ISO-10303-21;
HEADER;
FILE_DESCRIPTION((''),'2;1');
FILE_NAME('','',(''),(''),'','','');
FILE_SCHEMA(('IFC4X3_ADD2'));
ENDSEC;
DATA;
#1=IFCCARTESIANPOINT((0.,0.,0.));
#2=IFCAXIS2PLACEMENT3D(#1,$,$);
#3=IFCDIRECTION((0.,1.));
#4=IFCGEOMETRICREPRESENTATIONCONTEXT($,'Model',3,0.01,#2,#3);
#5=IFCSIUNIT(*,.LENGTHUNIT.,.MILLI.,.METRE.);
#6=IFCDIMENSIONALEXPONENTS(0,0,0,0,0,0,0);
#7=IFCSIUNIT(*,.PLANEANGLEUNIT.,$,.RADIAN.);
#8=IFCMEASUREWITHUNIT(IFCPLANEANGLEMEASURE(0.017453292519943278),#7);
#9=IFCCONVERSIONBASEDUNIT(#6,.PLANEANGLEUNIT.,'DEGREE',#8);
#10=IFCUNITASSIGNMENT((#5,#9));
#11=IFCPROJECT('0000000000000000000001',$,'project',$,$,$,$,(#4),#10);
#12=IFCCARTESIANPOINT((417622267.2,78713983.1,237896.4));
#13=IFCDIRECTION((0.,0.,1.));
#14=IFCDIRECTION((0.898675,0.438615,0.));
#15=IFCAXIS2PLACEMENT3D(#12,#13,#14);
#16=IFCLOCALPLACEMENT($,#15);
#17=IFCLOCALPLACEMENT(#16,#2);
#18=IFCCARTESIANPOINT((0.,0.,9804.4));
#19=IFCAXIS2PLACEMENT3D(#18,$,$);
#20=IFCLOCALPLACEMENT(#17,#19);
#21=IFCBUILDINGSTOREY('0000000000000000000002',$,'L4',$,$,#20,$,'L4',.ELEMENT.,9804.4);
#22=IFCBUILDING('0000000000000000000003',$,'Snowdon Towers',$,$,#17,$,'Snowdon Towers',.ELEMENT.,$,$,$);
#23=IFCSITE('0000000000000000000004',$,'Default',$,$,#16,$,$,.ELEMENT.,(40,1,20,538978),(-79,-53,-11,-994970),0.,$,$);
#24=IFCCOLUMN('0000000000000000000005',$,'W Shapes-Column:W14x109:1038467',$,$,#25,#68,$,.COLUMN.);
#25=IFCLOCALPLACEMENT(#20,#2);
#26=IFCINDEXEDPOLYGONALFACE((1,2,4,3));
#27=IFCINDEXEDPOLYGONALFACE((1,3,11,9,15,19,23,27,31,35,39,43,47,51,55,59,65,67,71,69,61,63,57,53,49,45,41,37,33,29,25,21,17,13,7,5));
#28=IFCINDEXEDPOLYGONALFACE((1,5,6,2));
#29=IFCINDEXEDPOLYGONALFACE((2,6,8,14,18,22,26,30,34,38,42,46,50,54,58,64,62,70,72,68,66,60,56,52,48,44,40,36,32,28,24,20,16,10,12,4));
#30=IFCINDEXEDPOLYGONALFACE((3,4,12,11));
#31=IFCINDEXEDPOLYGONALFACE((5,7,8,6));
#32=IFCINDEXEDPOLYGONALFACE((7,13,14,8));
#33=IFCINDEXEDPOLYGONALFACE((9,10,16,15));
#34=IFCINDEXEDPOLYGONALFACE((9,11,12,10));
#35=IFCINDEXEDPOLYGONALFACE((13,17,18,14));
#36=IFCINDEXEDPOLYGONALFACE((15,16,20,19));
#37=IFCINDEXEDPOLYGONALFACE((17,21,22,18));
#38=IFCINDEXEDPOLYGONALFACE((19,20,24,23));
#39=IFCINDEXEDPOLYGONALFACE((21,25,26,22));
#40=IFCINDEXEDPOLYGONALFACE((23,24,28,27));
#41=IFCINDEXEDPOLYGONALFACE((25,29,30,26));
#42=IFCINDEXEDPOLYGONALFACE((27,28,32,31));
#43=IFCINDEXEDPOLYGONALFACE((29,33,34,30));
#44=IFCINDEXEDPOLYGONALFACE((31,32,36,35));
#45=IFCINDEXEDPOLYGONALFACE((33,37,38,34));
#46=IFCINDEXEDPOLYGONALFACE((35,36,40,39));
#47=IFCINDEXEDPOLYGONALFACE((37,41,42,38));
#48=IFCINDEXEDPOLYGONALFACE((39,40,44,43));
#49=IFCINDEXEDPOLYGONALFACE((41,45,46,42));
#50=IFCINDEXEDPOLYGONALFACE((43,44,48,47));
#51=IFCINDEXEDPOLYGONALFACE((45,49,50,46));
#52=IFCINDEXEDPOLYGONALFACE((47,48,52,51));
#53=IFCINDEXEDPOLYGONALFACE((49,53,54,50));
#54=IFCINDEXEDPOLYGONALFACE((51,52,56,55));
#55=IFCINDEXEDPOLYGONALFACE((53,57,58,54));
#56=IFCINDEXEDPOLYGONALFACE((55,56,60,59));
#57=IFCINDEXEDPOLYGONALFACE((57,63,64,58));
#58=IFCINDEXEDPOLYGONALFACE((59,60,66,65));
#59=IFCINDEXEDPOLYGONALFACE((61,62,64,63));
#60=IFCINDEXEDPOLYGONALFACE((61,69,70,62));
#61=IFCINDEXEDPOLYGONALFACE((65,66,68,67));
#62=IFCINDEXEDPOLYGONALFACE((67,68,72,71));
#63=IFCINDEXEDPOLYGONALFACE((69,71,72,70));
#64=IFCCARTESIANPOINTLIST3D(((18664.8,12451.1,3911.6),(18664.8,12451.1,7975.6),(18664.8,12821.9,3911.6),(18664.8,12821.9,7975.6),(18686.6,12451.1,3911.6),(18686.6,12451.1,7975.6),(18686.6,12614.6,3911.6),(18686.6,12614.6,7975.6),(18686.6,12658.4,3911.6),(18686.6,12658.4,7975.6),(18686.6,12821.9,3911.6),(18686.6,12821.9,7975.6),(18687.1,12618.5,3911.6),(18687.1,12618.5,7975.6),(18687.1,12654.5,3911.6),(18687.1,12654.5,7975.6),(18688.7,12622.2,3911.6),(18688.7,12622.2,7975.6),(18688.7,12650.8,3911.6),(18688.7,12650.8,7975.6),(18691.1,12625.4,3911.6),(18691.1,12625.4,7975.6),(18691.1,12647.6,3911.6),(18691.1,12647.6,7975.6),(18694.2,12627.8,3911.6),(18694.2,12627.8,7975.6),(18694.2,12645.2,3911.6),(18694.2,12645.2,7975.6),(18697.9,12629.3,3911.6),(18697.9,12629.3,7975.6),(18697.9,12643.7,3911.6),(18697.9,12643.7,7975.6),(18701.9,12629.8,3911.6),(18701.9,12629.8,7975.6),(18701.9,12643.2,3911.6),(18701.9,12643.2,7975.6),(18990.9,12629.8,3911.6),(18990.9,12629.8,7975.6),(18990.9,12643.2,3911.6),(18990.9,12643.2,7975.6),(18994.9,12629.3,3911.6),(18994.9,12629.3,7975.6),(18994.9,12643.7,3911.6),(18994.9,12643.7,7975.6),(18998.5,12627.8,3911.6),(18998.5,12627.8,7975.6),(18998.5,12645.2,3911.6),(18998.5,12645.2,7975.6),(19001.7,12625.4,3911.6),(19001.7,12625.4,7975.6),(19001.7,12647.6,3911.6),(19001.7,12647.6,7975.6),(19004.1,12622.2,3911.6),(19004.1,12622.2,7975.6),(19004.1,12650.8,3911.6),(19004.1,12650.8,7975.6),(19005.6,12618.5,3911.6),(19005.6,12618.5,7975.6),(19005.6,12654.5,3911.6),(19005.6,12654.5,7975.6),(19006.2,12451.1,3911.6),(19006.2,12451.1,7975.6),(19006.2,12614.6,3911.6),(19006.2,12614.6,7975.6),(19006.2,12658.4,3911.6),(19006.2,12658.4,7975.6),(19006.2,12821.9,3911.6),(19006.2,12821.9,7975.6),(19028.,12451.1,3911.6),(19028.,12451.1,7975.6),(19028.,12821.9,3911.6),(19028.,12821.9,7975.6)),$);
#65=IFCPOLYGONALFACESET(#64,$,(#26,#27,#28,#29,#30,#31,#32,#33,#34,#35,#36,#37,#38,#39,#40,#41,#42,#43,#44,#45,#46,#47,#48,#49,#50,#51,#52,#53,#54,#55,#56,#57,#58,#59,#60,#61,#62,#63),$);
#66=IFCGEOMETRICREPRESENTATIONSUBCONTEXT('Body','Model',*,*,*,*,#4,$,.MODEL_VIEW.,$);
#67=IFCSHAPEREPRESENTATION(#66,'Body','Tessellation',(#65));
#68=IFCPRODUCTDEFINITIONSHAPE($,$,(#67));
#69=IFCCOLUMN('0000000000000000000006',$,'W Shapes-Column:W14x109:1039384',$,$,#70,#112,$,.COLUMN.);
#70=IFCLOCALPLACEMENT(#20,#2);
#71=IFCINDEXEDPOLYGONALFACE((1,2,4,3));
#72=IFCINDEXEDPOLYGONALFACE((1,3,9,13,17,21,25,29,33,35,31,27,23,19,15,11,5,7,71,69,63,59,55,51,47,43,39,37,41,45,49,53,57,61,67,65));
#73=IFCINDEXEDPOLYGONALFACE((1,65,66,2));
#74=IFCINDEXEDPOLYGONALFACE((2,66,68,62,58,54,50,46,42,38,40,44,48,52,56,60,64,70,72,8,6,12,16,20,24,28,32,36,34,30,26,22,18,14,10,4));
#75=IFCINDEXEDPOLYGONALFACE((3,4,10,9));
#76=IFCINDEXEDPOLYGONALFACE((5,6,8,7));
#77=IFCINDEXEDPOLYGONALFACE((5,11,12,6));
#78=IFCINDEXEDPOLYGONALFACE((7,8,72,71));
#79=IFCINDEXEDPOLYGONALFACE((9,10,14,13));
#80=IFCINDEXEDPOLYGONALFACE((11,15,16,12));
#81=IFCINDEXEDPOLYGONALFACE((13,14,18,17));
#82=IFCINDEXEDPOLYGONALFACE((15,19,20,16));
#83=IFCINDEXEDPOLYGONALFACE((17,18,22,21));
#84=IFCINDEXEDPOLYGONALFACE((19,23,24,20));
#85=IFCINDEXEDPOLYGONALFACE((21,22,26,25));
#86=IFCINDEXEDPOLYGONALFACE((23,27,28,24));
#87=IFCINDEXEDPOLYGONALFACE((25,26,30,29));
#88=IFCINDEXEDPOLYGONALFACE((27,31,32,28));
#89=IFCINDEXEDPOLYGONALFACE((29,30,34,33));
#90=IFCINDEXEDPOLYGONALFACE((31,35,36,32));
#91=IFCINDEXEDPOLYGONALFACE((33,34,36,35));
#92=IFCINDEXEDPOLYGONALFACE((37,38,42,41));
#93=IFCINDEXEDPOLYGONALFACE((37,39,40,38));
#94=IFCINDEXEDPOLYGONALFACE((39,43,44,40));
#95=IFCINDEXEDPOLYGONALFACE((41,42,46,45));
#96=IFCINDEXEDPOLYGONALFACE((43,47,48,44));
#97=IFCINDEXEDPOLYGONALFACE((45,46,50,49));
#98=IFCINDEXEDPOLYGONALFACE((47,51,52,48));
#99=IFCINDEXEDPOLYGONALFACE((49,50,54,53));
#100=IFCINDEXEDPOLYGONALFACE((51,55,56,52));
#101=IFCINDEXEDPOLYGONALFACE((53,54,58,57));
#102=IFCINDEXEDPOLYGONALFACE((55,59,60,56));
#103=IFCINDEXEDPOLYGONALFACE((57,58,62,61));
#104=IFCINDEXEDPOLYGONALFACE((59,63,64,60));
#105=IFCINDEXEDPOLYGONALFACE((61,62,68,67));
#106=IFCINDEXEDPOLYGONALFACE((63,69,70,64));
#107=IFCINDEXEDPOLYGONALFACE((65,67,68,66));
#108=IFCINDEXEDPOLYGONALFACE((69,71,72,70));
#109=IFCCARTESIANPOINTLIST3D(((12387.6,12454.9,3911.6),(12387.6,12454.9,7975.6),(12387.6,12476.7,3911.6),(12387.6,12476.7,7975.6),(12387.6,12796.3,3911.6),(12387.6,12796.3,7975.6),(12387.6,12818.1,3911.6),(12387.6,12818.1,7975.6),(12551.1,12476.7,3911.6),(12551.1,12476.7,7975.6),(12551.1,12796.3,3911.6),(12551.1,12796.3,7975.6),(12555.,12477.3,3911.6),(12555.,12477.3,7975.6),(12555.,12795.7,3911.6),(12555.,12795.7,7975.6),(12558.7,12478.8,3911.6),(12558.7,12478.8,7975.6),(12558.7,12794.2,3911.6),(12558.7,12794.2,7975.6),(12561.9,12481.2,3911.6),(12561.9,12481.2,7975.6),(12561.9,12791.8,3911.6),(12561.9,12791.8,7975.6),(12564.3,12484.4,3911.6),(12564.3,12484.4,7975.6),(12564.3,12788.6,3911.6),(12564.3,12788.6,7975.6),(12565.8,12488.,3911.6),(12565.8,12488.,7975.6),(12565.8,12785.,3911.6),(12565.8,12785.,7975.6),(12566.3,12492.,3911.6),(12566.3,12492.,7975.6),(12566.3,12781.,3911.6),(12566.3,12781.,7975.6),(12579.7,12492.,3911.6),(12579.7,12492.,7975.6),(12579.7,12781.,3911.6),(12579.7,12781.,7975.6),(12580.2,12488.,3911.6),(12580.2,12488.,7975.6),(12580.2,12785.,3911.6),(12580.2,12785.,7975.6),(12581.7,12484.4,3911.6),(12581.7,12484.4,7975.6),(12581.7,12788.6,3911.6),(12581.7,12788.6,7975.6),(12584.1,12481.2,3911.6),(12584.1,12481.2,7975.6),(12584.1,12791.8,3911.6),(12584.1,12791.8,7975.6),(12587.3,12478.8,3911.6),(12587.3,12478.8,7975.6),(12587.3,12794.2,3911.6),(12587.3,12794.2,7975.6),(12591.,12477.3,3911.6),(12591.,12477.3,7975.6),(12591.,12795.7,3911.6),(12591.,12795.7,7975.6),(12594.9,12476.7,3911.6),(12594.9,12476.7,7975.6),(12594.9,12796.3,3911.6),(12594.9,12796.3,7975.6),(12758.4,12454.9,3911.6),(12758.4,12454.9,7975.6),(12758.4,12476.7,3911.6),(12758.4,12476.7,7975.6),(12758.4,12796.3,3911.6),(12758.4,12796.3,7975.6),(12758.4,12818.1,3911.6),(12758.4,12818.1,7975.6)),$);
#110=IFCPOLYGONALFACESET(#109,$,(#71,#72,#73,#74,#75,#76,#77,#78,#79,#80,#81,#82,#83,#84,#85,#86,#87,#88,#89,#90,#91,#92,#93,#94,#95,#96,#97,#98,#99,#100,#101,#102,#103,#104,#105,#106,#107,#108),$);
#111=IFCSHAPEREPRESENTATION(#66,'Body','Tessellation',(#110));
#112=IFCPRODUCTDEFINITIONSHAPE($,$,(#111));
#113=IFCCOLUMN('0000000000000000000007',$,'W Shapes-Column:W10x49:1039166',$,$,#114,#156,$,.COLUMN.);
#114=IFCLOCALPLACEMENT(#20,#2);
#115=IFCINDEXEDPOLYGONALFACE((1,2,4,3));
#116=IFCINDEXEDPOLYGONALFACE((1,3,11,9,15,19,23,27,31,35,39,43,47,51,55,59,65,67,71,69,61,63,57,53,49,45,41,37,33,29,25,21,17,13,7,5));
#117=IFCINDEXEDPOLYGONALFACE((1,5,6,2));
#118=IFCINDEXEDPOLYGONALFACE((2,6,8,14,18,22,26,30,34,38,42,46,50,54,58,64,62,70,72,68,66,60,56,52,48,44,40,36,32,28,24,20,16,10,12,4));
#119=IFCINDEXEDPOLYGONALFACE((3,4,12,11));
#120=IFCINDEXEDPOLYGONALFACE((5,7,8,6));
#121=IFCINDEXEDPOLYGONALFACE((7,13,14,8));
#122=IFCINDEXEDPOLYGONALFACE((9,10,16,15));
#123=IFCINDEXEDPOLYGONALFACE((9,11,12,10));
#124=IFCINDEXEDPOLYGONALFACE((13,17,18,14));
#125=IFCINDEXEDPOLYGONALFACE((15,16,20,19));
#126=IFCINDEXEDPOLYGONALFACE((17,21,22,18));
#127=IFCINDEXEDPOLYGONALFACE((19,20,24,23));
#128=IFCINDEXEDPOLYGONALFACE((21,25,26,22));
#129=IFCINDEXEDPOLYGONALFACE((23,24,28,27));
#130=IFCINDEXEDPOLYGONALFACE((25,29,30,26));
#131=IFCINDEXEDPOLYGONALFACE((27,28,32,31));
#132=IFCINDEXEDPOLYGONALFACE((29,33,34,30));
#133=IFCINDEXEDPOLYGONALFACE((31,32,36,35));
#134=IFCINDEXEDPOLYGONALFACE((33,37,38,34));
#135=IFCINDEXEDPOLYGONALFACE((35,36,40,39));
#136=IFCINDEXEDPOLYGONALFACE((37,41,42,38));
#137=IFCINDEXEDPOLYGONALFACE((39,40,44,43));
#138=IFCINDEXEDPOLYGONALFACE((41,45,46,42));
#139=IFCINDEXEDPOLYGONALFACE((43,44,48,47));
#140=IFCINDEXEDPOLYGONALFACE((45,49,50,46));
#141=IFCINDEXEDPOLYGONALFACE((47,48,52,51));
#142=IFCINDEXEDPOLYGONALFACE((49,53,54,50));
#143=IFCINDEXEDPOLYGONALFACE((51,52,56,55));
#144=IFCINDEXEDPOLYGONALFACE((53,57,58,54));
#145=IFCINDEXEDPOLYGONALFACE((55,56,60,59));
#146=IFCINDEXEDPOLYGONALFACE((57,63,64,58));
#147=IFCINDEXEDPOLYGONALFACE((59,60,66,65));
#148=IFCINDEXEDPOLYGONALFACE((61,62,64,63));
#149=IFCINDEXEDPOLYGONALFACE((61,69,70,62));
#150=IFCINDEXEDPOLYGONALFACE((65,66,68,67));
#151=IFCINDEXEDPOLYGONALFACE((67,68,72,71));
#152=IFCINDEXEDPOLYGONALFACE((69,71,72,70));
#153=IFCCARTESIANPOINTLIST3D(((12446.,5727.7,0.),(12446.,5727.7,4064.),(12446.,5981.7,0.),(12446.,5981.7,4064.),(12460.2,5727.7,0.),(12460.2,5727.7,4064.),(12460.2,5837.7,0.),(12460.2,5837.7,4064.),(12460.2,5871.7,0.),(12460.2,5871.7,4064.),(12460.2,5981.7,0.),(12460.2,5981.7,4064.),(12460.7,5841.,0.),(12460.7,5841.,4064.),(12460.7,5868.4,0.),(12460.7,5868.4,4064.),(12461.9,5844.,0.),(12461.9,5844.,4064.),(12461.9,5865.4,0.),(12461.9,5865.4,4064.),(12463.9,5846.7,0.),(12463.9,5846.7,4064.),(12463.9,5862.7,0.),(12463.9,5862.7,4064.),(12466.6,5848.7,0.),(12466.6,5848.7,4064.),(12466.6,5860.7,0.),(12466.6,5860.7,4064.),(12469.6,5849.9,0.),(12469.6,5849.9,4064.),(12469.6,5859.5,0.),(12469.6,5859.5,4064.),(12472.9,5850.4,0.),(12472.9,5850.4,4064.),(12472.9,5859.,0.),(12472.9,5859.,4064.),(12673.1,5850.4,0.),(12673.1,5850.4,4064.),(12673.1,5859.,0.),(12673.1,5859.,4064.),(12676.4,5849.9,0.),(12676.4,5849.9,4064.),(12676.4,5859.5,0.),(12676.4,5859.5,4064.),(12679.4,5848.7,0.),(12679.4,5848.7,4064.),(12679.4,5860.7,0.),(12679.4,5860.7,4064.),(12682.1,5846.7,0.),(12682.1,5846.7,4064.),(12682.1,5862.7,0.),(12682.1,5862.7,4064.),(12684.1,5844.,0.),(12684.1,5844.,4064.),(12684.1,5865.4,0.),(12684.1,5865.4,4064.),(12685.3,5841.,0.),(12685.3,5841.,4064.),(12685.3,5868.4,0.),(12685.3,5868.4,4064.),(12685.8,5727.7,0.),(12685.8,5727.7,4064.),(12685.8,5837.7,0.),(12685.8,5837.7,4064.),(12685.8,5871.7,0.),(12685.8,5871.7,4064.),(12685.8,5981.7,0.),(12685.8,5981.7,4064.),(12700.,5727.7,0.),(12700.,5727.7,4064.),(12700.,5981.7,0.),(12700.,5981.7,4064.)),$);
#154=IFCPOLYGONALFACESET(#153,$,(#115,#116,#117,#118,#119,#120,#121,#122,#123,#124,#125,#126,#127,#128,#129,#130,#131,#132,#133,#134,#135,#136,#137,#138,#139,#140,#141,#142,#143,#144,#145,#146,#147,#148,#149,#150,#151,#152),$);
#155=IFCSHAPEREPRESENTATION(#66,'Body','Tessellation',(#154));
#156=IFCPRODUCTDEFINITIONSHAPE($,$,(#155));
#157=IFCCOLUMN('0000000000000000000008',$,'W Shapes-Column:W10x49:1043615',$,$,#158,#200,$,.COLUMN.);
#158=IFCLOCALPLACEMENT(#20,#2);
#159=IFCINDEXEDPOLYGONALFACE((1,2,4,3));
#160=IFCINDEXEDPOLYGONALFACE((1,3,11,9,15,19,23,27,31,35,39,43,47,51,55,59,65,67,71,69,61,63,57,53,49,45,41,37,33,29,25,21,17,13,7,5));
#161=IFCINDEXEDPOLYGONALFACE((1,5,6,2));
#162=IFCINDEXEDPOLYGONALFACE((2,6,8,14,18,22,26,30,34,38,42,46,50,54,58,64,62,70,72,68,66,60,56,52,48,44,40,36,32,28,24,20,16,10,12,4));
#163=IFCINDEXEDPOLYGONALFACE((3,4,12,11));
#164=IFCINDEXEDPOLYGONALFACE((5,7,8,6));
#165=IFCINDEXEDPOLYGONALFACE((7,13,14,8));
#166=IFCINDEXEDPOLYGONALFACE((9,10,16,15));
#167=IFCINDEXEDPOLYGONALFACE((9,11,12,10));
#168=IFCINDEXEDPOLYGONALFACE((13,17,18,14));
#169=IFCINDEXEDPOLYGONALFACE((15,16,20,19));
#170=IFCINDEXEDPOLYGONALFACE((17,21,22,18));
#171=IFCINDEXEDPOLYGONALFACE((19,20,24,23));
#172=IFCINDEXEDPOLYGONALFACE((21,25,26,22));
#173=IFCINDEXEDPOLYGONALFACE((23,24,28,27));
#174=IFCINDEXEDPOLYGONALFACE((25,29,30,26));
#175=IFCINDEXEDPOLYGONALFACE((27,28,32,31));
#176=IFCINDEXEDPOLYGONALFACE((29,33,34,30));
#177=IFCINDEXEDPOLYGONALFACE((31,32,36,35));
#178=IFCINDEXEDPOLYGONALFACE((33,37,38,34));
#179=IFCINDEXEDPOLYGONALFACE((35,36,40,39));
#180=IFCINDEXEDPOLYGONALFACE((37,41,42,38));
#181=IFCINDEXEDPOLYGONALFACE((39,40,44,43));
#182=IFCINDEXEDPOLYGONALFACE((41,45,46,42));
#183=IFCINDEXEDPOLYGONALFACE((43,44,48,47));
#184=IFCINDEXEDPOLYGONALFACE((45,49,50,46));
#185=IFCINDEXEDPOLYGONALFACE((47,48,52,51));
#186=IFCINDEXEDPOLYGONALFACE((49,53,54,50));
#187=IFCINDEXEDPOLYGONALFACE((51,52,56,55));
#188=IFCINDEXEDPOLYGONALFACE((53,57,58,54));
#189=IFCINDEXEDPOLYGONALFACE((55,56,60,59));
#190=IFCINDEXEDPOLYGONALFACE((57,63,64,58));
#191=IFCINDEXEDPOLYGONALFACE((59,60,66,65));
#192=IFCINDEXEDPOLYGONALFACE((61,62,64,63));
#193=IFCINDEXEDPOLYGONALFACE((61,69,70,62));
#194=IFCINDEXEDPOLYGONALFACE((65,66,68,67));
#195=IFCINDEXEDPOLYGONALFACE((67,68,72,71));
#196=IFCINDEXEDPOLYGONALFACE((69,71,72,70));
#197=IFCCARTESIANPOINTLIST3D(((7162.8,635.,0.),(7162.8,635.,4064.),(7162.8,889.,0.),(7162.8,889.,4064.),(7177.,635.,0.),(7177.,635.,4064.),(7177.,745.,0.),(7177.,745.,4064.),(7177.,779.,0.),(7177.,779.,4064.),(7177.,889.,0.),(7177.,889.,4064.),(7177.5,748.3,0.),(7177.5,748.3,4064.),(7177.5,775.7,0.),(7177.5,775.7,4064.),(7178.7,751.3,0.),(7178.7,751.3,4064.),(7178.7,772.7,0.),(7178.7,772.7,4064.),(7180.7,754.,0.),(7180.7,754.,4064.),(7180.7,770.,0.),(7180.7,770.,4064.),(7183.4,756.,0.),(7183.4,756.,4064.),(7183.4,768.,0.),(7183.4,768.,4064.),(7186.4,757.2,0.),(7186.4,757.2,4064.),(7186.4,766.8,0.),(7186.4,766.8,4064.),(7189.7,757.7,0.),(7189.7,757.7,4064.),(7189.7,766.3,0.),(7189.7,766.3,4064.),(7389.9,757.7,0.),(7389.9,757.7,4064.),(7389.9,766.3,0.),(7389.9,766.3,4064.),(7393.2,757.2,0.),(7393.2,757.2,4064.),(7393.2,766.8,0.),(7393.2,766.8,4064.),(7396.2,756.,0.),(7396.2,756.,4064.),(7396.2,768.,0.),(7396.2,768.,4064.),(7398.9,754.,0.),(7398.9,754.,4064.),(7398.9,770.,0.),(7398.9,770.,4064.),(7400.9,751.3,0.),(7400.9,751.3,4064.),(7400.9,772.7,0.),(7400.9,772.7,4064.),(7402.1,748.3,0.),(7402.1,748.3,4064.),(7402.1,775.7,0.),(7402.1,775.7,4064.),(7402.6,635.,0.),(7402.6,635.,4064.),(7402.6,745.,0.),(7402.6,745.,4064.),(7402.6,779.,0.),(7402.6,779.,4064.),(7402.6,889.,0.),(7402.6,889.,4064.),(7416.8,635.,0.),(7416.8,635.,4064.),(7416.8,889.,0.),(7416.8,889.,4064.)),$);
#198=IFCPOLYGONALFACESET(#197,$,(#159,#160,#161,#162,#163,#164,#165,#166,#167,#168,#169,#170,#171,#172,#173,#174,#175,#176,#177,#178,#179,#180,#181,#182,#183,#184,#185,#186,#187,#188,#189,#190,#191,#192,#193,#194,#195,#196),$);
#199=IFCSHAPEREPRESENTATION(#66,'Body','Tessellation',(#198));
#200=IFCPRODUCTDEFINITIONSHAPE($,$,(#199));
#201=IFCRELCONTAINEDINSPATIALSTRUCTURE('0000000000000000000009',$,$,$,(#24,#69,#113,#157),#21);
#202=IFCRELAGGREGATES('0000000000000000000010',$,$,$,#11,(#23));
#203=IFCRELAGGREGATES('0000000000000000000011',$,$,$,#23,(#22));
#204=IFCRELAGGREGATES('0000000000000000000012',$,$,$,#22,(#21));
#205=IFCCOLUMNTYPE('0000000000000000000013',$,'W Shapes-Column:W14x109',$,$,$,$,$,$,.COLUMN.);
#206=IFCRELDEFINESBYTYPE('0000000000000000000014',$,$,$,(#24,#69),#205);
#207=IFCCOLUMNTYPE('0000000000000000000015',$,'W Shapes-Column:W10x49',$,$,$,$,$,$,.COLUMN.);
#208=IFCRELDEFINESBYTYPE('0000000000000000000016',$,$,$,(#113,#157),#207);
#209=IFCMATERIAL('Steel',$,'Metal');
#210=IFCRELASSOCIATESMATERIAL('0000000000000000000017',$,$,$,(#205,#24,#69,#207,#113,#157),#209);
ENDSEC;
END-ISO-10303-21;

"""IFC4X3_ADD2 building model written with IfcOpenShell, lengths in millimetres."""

from ifc_helpers import new_model, entity, si_unit, converted_unit, direction, frame, frame_2d, origin, place, context, subcontext, project, spatial, i_section, extrude, source, transform, mapped, material, material_profile, profile_set, profile_usage, type_object, type_shapes, element, save


model = new_model("IFC4X3_ADD2")

# Units and contexts
model_context = context("Model", 3, precision=0.01, world=origin(), true_north=direction((0.0, 1.0)))
body_context = subcontext(model_context, "Body", "Model", "MODEL_VIEW")
ifc_project = project(units=[si_unit("LENGTHUNIT", "METRE", prefix="MILLI"), converted_unit("PLANEANGLEUNIT", "DEGREE", entity("IfcPlaneAngleMeasure", 0.017453292519943278), si_unit("PLANEANGLEUNIT", "RADIAN"), dimensions=[0, 0, 0, 0, 0, 0, 0])], contexts=[model_context])

# Site, building, storey
site_placement = place(None, frame((417622267.2, 78713983.1, 237896.4), z_axis=(0.0, 0.0, 1.0), x_axis=(0.898675, 0.438615, 0.0)))
site = spatial("IfcSite", under=ifc_project, at=site_placement, Name="Default", CompositionType="ELEMENT", RefLatitude=(40, 1, 20, 538978), RefLongitude=(-79, -53, -11, -994970), RefElevation=0.0)
building_placement = place(site_placement, origin())
building = spatial("IfcBuilding", under=site, at=building_placement, Name="Snowdon Towers", LongName="Snowdon Towers", CompositionType="ELEMENT")
storey_placement = place(building_placement, frame((0.0, 0.0, 9804.4)))
storey = spatial("IfcBuildingStorey", under=building, at=storey_placement, Name="L4", LongName="L4", CompositionType="ELEMENT", Elevation=9804.4)

# Columns
ifc_material_1 = material(Name="Steel", Category="Metal")
ifc_material_profile_1 = material_profile(ifc_material_1, i_section(OverallWidth=370.8, OverallDepth=363.2, WebThickness=13.3, FlangeThickness=21.8, FilletRadius=15.2, at=frame_2d((0.0, 0.0), x_axis=(1.0, 0.0))), Name="W14x109")
ifc_profile_set_1 = profile_set([ifc_material_profile_1], Name="W14x109")
ifc_profile_usage_1 = profile_usage(ifc_profile_set_1)
column_type_1 = type_object("IfcColumnType", Name="W Shapes-Column:W14x109", PredefinedType="COLUMN", material=ifc_profile_set_1)
shared_shape_1 = source(origin(), body_context, "Body", "SweptSolid", [
    extrude(i_section(OverallWidth=370.8, OverallDepth=363.2, WebThickness=13.3, FlangeThickness=21.8, FilletRadius=15.2, at=frame_2d((0.0, 0.0), x_axis=(1.0, 0.0))), frame((0.0, 0.0, 13716.0), z_axis=(0.0, 0.0, 1.0), x_axis=(-1.0, 0.0, 0.0)), (0.0, 0.0, 1.0), 4064.0),
])
type_shapes(column_type_1, [shared_shape_1])
for number, where, z_axis, x_axis, name in (
    (1, (18846.4, 12636.5, -9804.4), (0.0, 0.0, 1.0), (0.0, 1.0, 0.0), "W Shapes-Column:W14x109:1038467"),
    (2, (12573.0, 12636.5, -9804.4), (0.0, 0.0, 1.0), (-1.0, 0.0, 0.0), "W Shapes-Column:W14x109:1039384"),
):
    element("IfcColumn", number, at=place(storey_placement, frame(where, z_axis=z_axis, x_axis=x_axis)), inside=storey, type_object=column_type_1, material=ifc_profile_usage_1, Name=name, PredefinedType="COLUMN", context=body_context, shape_type="MappedRepresentation", body=[
        mapped(shared_shape_1, transform((0.0, 0.0, 0.0), scale=1.0)),
    ])
ifc_material_profile_2 = material_profile(ifc_material_1, i_section(OverallWidth=254.0, OverallDepth=254.0, WebThickness=8.6, FlangeThickness=14.2, FilletRadius=12.7, at=frame_2d((0.0, 0.0), x_axis=(1.0, 0.0))), Name="W10x49")
ifc_profile_set_2 = profile_set([ifc_material_profile_2], Name="W10x49")
ifc_profile_usage_2 = profile_usage(ifc_profile_set_2)
column_type_2 = type_object("IfcColumnType", Name="W Shapes-Column:W10x49", PredefinedType="COLUMN", material=ifc_profile_set_2)
shared_shape_2 = source(origin(), body_context, "Body", "SweptSolid", [
    extrude(i_section(OverallWidth=254.0, OverallDepth=254.0, WebThickness=8.6, FlangeThickness=14.2, FilletRadius=12.7, at=frame_2d((0.0, 0.0), x_axis=(1.0, 0.0))), frame((0.0, 0.0, 9804.4), z_axis=(0.0, 0.0, 1.0), x_axis=(-1.0, 0.0, 0.0)), (0.0, 0.0, 1.0), 4064.0),
])
type_shapes(column_type_2, [shared_shape_2])
for number, where, z_axis, x_axis, name in (
    (3, (12573.0, 5854.7, -9804.4), (0.0, 0.0, 1.0), (0.0, 1.0, 0.0), "W Shapes-Column:W10x49:1039166"),
    (4, (7289.8, 762.0, -9804.4), (0.0, 0.0, 1.0), (0.0, 1.0, 0.0), "W Shapes-Column:W10x49:1043615"),
):
    element("IfcColumn", number, at=place(storey_placement, frame(where, z_axis=z_axis, x_axis=x_axis)), inside=storey, type_object=column_type_2, material=ifc_profile_usage_2, Name=name, PredefinedType="COLUMN", context=body_context, shape_type="MappedRepresentation", body=[
        mapped(shared_shape_2, transform((0.0, 0.0, 0.0), scale=1.0)),
    ])

save(model, "model.ifc")
